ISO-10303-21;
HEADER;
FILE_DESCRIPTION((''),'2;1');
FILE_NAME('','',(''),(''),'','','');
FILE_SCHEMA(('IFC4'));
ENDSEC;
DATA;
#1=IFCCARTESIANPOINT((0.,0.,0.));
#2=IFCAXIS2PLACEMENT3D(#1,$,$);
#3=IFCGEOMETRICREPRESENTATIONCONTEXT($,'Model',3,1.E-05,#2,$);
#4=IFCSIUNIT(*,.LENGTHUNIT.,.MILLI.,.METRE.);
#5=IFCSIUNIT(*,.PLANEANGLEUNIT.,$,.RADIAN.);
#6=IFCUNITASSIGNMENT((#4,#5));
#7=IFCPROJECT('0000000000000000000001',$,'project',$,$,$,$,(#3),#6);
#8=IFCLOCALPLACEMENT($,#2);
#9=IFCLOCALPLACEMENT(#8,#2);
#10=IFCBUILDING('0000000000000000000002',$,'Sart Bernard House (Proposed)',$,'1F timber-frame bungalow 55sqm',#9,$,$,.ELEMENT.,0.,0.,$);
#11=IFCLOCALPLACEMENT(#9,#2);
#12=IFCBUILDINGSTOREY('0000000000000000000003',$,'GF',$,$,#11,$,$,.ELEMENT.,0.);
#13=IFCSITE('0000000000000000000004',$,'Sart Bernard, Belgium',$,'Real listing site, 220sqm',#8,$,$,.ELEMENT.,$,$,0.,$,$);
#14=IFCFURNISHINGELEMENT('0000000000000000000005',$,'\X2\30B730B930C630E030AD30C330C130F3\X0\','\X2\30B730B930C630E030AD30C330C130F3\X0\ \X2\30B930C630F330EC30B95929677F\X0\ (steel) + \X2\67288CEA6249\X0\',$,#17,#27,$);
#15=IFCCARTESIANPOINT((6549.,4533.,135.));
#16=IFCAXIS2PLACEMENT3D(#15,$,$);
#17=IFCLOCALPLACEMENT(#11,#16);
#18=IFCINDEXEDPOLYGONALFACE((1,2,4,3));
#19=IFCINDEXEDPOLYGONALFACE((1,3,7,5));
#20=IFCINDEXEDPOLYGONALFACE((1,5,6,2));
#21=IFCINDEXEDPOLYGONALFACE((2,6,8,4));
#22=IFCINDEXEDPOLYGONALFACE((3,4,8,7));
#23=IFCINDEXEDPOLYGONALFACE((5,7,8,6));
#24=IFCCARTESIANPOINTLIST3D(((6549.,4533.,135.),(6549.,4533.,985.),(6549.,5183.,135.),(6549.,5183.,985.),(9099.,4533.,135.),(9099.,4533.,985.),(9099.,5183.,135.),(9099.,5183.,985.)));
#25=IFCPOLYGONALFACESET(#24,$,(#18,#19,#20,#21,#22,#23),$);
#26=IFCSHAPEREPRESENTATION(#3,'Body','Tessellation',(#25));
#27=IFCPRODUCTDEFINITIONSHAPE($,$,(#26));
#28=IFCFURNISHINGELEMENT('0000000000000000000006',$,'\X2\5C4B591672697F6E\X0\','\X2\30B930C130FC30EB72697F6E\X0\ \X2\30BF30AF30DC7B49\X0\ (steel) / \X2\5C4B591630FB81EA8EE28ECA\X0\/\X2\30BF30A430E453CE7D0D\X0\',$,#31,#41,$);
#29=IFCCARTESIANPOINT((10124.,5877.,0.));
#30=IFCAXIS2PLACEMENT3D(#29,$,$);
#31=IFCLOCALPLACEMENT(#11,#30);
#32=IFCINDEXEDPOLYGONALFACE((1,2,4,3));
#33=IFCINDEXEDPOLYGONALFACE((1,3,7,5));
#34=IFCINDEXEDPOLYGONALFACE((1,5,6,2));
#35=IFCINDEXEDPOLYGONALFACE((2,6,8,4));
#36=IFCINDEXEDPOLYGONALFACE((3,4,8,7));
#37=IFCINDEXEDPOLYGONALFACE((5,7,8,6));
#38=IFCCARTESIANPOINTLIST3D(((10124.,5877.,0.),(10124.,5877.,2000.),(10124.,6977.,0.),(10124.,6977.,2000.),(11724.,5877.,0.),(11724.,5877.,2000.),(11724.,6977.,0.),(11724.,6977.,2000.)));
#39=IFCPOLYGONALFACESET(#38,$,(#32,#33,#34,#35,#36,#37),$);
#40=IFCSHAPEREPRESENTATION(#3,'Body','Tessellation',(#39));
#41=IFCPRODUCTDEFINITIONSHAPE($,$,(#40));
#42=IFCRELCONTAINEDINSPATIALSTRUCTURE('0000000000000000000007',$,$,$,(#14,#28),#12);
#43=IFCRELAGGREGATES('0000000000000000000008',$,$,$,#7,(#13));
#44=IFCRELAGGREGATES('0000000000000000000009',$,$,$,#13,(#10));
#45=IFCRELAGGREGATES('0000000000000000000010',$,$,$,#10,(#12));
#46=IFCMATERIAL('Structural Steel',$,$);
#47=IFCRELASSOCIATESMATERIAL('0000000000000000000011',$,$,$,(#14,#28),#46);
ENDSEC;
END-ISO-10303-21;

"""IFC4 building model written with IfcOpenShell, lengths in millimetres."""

from ifc_helpers import new_model, si_unit, frame, frame_2d, origin, place, context, project, spatial, rectangle, extrude, material, element, save


model = new_model("IFC4")

# Units and contexts
model_context = context("Model", 3, precision=1e-05, world=origin())
ifc_project = project(units=[si_unit("LENGTHUNIT", "METRE", prefix="MILLI"), si_unit("PLANEANGLEUNIT", "RADIAN")], contexts=[model_context])

# Site, building, storey
site_placement = place(None, origin())
site = spatial("IfcSite", under=ifc_project, at=site_placement, Name="Sart Bernard, Belgium", ObjectType="Real listing site, 220sqm", CompositionType="ELEMENT", RefElevation=0.0)
building_placement = place(site_placement, origin())
building = spatial("IfcBuilding", under=site, at=building_placement, Name="Sart Bernard House (Proposed)", ObjectType="1F timber-frame bungalow 55sqm", CompositionType="ELEMENT", ElevationOfRefHeight=0.0, ElevationOfTerrain=0.0)
storey_placement = place(building_placement, origin())
storey = spatial("IfcBuildingStorey", under=building, at=storey_placement, Name="GF", CompositionType="ELEMENT", Elevation=0.0)

# Shared definitions
ifc_material_1 = material(Name="Structural Steel")

# Furnishing elements
furnishing_1_placement = place(storey_placement, frame((6549.0, 4533.0, 135.0)))
element("IfcFurnishingElement", 1, at=furnishing_1_placement, inside=storey, material=ifc_material_1, Name="システムキッチン", Description="システムキッチン ステンレス天板 (steel) + 木質扉", context=model_context, shape_type="SweptSolid", body=[
    extrude(rectangle(XDim=2550.0, YDim=650.0, at=frame_2d((1275.0, 325.0))), frame((6549.0, 4533.0, 135.0)), (0.0, 0.0, 1.0), 850.0),
])
furnishing_2_placement = place(storey_placement, frame((10124.0, 5877.0, 0.0)))
element("IfcFurnishingElement", 2, at=furnishing_2_placement, inside=storey, material=ifc_material_1, Name="屋外物置", Description="スチール物置 タクボ等 (steel) / 屋外・自転車/タイヤ収納", context=model_context, shape_type="SweptSolid", body=[
    extrude(rectangle(XDim=1600.0, YDim=1100.0, at=frame_2d((800.0, 550.0))), frame((10124.0, 5877.0, 0.0)), (0.0, 0.0, 1.0), 2000.0),
])

save(model, "model.ifc")
